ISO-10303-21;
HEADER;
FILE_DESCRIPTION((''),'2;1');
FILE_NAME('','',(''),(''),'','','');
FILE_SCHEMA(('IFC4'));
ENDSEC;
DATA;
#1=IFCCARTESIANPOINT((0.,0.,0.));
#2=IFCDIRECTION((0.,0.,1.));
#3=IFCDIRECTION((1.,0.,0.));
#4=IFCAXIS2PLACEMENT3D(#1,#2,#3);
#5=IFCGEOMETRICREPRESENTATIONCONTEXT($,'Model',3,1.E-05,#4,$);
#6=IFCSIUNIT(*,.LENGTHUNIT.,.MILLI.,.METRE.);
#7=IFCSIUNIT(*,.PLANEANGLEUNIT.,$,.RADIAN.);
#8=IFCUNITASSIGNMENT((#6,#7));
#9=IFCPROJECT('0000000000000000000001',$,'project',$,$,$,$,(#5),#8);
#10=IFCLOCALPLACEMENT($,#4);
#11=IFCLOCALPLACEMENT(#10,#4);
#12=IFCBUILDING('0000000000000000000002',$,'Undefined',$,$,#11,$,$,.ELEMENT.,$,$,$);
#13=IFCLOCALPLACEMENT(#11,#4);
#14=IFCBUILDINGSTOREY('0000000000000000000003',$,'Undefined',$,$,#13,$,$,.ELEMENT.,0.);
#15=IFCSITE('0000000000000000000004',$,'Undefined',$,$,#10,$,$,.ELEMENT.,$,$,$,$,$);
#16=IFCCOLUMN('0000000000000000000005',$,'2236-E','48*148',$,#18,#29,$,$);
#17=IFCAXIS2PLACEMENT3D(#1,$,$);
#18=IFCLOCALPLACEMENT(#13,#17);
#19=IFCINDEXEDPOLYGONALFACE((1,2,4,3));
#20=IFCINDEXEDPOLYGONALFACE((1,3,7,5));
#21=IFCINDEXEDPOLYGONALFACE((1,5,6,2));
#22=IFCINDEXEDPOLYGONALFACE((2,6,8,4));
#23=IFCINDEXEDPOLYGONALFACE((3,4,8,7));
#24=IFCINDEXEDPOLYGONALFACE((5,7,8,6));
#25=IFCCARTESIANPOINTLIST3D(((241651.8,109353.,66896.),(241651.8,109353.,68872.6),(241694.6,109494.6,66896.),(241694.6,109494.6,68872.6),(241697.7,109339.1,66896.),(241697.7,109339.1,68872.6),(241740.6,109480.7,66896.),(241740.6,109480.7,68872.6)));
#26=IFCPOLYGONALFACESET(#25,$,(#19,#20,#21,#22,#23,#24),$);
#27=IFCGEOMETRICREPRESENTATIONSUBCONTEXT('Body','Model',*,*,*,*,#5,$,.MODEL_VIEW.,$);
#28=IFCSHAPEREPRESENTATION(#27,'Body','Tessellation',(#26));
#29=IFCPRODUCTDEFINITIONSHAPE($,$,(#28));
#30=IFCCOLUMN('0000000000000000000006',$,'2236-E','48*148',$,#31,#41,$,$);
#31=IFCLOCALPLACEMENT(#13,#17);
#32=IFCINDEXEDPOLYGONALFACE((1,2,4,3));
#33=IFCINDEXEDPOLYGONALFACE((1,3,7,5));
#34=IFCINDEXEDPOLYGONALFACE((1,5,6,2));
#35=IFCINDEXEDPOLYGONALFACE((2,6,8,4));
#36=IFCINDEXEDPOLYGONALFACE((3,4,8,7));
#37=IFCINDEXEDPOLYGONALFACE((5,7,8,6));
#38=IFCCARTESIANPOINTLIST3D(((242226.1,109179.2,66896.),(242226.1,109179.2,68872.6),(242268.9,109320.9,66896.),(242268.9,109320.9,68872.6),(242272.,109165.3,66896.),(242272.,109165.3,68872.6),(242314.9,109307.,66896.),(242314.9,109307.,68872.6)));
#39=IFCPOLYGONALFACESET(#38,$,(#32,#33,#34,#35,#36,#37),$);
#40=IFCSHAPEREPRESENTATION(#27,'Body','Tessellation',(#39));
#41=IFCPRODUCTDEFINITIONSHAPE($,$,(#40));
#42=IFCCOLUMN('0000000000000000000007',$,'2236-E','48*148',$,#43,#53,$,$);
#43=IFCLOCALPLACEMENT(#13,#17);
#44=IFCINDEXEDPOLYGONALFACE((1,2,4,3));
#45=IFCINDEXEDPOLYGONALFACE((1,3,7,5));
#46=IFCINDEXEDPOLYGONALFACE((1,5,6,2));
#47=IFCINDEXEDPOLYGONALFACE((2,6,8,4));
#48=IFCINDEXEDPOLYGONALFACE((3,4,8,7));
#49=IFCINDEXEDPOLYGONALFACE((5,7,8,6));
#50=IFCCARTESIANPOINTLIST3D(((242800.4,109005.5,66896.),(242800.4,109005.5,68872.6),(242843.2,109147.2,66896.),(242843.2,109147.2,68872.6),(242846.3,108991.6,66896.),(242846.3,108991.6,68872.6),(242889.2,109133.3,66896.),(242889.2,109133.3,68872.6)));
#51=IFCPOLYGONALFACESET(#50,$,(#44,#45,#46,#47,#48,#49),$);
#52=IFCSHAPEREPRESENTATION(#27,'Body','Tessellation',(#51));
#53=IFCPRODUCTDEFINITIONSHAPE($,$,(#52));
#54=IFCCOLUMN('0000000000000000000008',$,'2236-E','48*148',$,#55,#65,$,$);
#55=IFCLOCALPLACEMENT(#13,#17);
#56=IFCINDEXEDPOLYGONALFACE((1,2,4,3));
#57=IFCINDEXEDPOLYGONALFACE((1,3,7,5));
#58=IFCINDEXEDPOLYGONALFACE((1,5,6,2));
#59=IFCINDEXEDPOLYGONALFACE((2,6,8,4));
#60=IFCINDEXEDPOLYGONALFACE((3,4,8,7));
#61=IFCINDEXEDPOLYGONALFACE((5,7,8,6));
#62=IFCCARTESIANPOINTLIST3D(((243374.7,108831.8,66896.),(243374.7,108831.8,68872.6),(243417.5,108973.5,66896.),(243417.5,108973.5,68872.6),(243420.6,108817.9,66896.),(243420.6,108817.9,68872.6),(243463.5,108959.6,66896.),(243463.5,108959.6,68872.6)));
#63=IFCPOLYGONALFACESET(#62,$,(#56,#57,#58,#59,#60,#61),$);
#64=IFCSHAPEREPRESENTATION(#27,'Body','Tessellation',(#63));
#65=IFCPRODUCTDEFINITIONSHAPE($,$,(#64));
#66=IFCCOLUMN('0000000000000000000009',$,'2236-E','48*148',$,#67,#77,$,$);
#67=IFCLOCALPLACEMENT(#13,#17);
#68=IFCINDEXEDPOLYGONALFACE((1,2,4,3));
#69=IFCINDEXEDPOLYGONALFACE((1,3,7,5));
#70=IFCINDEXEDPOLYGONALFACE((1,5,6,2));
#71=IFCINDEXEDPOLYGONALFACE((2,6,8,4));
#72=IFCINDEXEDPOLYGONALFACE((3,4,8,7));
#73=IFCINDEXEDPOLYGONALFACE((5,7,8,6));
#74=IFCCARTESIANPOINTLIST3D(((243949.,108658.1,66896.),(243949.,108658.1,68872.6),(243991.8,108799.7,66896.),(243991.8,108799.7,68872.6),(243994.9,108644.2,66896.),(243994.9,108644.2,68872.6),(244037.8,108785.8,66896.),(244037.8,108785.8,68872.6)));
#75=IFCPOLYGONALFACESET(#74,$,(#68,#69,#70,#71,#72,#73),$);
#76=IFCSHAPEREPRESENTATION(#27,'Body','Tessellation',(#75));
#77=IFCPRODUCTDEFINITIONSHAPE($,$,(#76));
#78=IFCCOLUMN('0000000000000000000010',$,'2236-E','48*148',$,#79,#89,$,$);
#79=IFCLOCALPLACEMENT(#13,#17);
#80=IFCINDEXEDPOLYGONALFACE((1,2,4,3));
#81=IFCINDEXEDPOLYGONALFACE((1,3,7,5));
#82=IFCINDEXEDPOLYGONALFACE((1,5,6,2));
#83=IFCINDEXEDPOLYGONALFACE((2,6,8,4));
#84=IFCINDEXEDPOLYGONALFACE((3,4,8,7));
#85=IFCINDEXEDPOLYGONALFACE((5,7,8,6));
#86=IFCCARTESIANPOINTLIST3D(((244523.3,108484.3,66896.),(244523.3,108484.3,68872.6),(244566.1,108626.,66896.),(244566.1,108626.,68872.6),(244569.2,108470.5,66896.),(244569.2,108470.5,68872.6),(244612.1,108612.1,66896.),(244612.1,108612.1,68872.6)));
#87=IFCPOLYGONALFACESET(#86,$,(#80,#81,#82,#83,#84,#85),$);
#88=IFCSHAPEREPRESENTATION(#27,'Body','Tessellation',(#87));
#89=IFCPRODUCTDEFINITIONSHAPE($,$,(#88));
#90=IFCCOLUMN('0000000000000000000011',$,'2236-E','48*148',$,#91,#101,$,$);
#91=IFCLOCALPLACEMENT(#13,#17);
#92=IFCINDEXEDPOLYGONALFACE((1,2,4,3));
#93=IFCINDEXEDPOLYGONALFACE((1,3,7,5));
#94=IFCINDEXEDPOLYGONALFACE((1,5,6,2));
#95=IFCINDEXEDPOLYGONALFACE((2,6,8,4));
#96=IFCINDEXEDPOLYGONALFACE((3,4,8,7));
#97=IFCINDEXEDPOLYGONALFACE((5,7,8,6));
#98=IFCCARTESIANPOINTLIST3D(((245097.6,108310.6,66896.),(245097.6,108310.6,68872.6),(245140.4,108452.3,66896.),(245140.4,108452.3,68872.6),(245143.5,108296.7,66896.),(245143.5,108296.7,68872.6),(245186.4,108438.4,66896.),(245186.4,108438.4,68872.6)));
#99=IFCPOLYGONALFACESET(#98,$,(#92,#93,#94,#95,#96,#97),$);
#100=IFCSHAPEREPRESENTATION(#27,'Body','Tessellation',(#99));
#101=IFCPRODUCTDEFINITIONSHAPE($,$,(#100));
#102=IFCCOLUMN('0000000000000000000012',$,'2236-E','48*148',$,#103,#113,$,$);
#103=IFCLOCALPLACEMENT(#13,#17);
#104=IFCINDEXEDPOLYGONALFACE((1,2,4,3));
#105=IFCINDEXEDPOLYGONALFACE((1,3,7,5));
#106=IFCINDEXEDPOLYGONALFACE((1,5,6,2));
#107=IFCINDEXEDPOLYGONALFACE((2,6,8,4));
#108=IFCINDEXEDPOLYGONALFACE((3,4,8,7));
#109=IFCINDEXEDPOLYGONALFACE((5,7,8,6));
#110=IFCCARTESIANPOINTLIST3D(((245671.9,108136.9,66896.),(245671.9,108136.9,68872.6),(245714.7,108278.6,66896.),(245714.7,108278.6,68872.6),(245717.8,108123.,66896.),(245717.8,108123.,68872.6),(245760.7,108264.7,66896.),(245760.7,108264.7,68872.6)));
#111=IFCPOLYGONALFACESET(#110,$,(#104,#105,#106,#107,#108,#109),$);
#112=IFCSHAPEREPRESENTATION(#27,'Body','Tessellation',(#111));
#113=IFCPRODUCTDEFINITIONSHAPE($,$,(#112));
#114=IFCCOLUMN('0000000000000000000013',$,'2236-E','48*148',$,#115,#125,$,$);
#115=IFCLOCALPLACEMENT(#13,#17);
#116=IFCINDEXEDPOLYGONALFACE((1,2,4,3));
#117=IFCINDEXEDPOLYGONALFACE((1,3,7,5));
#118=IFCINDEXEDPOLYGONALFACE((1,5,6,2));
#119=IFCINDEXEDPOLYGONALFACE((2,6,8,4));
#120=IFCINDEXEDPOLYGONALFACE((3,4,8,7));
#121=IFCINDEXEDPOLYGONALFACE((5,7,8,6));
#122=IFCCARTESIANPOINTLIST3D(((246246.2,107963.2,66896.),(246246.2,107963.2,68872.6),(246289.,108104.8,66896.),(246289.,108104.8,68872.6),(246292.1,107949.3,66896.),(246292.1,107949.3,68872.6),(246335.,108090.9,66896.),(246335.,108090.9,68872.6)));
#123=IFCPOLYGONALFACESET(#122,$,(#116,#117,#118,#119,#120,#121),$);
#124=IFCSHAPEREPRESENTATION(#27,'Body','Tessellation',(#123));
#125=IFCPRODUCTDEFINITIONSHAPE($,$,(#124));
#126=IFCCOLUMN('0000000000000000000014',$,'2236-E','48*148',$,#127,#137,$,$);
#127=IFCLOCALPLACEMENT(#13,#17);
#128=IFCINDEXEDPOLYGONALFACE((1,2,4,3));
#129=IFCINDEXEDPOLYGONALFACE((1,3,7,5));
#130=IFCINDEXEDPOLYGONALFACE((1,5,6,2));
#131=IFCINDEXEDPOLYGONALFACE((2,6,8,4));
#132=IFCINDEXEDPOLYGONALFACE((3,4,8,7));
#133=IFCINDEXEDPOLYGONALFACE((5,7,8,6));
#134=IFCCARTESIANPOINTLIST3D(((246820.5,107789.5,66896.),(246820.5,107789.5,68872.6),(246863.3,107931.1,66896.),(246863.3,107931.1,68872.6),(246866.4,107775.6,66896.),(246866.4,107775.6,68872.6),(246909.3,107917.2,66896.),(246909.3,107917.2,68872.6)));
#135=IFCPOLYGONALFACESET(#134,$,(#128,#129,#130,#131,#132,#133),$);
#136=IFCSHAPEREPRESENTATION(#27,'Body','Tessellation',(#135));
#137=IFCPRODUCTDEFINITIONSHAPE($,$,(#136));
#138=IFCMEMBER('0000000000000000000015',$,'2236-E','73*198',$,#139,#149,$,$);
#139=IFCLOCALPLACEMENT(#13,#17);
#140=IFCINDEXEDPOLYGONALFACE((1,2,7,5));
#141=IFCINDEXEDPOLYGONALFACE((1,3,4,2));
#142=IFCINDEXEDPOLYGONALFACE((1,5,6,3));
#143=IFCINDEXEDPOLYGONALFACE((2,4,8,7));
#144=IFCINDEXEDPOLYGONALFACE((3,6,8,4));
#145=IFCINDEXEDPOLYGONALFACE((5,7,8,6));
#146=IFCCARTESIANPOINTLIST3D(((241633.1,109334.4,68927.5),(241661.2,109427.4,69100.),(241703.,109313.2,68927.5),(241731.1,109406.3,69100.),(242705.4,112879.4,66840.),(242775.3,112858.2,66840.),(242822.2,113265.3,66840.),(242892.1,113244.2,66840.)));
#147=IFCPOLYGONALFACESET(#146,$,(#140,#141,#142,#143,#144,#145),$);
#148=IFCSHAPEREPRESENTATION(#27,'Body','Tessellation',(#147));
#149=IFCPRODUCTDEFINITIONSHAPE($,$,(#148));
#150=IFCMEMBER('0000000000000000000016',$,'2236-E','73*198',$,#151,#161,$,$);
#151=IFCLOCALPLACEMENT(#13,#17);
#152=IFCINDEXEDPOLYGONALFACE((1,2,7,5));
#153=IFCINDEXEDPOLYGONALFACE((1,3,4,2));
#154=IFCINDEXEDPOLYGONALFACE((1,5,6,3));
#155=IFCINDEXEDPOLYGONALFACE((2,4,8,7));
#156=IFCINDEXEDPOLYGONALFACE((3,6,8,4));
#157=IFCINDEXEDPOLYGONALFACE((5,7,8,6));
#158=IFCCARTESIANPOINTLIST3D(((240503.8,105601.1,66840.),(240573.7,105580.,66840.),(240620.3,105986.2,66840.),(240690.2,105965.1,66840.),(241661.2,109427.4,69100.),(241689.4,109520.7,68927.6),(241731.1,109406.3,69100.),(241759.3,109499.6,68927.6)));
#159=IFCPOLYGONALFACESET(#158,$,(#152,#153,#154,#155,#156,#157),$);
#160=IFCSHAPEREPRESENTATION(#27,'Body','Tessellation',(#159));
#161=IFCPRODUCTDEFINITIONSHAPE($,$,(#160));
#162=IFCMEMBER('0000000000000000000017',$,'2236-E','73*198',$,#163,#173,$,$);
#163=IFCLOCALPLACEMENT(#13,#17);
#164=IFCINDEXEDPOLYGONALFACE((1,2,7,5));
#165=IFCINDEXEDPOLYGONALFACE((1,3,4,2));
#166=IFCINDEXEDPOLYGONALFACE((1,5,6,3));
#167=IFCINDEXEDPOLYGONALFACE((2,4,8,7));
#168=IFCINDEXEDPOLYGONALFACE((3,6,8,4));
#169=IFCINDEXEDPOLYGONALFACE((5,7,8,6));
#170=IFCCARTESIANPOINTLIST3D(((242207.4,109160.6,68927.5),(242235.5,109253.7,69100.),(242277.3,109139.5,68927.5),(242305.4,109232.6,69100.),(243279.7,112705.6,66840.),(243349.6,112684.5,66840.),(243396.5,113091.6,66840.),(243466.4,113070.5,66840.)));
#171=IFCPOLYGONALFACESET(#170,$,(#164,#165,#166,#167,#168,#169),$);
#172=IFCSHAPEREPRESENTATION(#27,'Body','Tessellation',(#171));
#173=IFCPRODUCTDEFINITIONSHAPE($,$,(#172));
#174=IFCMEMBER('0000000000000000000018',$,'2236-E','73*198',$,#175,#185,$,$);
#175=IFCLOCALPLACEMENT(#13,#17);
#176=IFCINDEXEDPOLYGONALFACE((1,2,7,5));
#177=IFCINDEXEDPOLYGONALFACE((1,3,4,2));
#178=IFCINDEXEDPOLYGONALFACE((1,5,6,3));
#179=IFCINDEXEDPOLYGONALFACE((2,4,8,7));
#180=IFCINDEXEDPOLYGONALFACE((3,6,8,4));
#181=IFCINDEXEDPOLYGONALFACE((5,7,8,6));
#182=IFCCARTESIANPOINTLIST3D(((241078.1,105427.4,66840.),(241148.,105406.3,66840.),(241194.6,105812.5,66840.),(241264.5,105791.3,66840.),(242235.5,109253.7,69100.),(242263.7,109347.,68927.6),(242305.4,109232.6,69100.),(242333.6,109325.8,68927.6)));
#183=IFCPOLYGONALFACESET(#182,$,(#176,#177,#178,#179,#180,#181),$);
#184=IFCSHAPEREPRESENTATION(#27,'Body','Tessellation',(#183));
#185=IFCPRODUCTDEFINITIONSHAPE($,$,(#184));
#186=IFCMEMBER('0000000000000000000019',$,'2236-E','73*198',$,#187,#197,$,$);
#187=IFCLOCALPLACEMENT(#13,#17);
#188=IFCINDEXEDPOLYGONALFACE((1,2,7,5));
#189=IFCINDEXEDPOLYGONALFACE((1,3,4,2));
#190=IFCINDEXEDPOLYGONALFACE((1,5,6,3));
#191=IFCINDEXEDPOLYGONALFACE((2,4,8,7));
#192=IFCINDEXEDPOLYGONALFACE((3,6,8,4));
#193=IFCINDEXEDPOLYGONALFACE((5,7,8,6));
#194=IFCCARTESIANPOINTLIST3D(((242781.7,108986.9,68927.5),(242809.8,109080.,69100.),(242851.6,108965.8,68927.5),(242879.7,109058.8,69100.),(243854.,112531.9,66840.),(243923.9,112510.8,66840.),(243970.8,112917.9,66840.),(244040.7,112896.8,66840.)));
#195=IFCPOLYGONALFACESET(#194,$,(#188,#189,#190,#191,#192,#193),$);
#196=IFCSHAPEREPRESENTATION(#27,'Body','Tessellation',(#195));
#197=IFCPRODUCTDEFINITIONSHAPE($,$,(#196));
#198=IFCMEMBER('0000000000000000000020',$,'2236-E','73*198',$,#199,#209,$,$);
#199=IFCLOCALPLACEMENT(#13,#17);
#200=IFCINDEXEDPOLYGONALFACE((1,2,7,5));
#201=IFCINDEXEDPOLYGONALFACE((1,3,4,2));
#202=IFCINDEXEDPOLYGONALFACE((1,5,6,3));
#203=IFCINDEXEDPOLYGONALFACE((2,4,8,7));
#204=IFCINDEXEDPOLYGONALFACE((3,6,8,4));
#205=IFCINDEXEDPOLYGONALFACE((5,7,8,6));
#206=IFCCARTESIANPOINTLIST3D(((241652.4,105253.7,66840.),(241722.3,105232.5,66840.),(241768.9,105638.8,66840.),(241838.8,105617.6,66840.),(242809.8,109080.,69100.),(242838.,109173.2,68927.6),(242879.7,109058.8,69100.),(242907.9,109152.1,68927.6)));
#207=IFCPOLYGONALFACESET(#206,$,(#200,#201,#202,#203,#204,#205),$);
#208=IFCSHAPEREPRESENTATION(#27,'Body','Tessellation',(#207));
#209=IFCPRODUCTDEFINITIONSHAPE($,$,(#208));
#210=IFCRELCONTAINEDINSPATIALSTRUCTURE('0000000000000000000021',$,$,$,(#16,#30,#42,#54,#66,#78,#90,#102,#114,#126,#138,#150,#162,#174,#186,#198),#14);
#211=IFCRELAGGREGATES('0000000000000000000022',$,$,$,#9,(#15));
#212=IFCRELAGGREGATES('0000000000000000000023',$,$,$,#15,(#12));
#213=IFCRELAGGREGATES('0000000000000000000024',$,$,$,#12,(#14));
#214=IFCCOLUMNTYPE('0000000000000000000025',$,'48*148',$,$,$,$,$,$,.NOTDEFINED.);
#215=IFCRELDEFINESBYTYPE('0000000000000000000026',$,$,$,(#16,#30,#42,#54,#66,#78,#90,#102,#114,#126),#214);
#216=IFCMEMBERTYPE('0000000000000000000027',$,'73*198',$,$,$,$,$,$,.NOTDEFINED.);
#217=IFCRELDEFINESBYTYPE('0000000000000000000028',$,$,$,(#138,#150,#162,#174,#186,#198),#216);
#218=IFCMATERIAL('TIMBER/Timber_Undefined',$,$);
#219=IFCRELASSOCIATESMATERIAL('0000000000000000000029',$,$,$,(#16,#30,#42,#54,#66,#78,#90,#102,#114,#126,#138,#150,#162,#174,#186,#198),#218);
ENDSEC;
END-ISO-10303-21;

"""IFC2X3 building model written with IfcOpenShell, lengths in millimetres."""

from ifc_helpers import new_model, si_unit, frame, origin_with_axes, origin_2d_with_axis, place, context, subcontext, project, spatial, rectangle, extrude, clip, halfspace, material, type_object, element, save


model = new_model("IFC2X3")

# Units and contexts
model_context = context("Model", 3, precision=1e-05, world=origin_with_axes())
body_context = subcontext(model_context, "Body", "Model", "MODEL_VIEW")
ifc_project = project(units=[si_unit("LENGTHUNIT", "METRE", prefix="MILLI"), si_unit("PLANEANGLEUNIT", "RADIAN")], contexts=[model_context])

# Site, building, storey
site_placement = place(None, origin_with_axes())
site = spatial("IfcSite", under=ifc_project, at=site_placement, Name="Undefined", CompositionType="ELEMENT")
building_placement = place(site_placement, origin_with_axes())
building = spatial("IfcBuilding", under=site, at=building_placement, Name="Undefined", CompositionType="ELEMENT")
storey_placement = place(building_placement, origin_with_axes())
storey = spatial("IfcBuildingStorey", under=building, at=storey_placement, Name="Undefined", CompositionType="ELEMENT", Elevation=0.0)

# Columns
ifc_material_1 = material(Name="TIMBER/Timber_Undefined")
column_type = type_object("IfcColumnType", Name="48*148", PredefinedType="NOTDEFINED")
for number, where, z_axis, x_axis, name in (
    (1, (241696.2, 109416.8, 68872.6), (0.0, 0.0, -1.0), (0.957167, -0.289538, 0.0), "2236-E"),
    (2, (242270.5, 109243.1, 68872.6), (0.0, 0.0, -1.0), (0.957167, -0.289538, 0.0), "2236-E"),
    (3, (242844.8, 109069.4, 68872.6), (0.0, 0.0, -1.0), (0.957167, -0.289538, 0.0), "2236-E"),
    (4, (243419.1, 108895.7, 68872.6), (0.0, 0.0, -1.0), (0.957167, -0.289538, 0.0), "2236-E"),
    (5, (243993.4, 108722.0, 68872.6), (0.0, 0.0, -1.0), (0.957167, -0.289538, 0.0), "2236-E"),
    (6, (244567.7, 108548.2, 68872.6), (0.0, 0.0, -1.0), (0.957167, -0.289538, 0.0), "2236-E"),
    (7, (245142.0, 108374.5, 68872.6), (0.0, 0.0, -1.0), (0.957167, -0.289538, 0.0), "2236-E"),
    (8, (245716.3, 108200.8, 68872.6), (0.0, 0.0, -1.0), (0.957167, -0.289538, 0.0), "2236-E"),
    (9, (246290.6, 108027.1, 68872.6), (0.0, 0.0, -1.0), (0.957167, -0.289538, 0.0), "2236-E"),
    (10, (246864.9, 107853.3, 68872.6), (0.0, 0.0, -1.0), (0.957167, -0.289538, 0.0), "2236-E"),
):
    element("IfcColumn", number, at=place(storey_placement, frame(where, z_axis=z_axis, x_axis=x_axis)), inside=storey, type_object=column_type, material=ifc_material_1, Name=name, Description="48*148", context=body_context, shape_type="SweptSolid", body=[
        extrude(rectangle(XDim=148.0, YDim=48.0, at=origin_2d_with_axis()), frame((0.0, 0.0, 1976.6), z_axis=(0.0, 0.0, -1.0), x_axis=(0.0, 1.0, 0.0)), (0.0, 0.0, 1.0), 1976.6),
    ])

# Members
member_type = type_object("IfcMemberType", Name="73*198", PredefinedType="NOTDEFINED")
member_1_placement = place(storey_placement, frame((241682.1, 109370.3, 69013.8), z_axis=(-0.957167, 0.289538, 0.0), x_axis=(0.252232, 0.833838, -0.491013)))
element("IfcMember", 11, at=member_1_placement, inside=storey, type_object=member_type, material=ifc_material_1, Name="2236-E", Description="73*198", context=body_context, shape_type="Clipping", body=[
    clip(extrude(rectangle(XDim=198.0, YDim=73.0, at=origin_2d_with_axis()), frame((9470.2, 0.0, 0.0), z_axis=(-1.0, 0.0, 0.0), x_axis=(0.0, -1.0, 0.0)), (0.0, 0.0, 1.0), 9470.2), halfspace(frame((4746.2, -179.9, -36.5), z_axis=(0.491013, 0.871152, 0.0), x_axis=(0.0, 0.0, 1.0)), False)),
])
member_2_placement = place(storey_placement, frame((241710.3, 109463.5, 69013.8), z_axis=(-0.957167, 0.289538, 0.0), x_axis=(-0.252047, -0.833226, -0.492144)))
element("IfcMember", 12, at=member_2_placement, inside=storey, type_object=member_type, material=ifc_material_1, Name="2236-E", Description="73*198", context=body_context, shape_type="Clipping", body=[
    clip(extrude(rectangle(XDim=198.0, YDim=73.0, at=origin_2d_with_axis()), frame((9448.4, 0.0, 0.0), z_axis=(-1.0, 0.0, 0.0), x_axis=(0.0, -1.0, 0.0)), (0.0, 0.0, 1.0), 9448.5), halfspace(frame((4746.1, 186.1, 36.5), z_axis=(0.492144, -0.870514, 0.0), x_axis=(0.0, 0.0, -1.0)), False)),
])
member_3_placement = place(storey_placement, frame((242256.4, 109196.6, 69013.8), z_axis=(-0.957167, 0.289538, 0.0), x_axis=(0.252232, 0.833838, -0.491013)))
element("IfcMember", 13, at=member_3_placement, inside=storey, type_object=member_type, material=ifc_material_1, Name="2236-E", Description="73*198", context=body_context, shape_type="Clipping", body=[
    clip(extrude(rectangle(XDim=198.0, YDim=73.0, at=origin_2d_with_axis()), frame((9470.2, 0.0, 0.0), z_axis=(-1.0, 0.0, 0.0), x_axis=(0.0, -1.0, 0.0)), (0.0, 0.0, 1.0), 9470.2), halfspace(frame((4746.2, -179.9, -36.5), z_axis=(0.491013, 0.871152, 0.0), x_axis=(0.0, 0.0, 1.0)), False)),
])
member_4_placement = place(storey_placement, frame((242284.6, 109289.8, 69013.8), z_axis=(-0.957167, 0.289538, 0.0), x_axis=(-0.252047, -0.833226, -0.492144)))
element("IfcMember", 14, at=member_4_placement, inside=storey, type_object=member_type, material=ifc_material_1, Name="2236-E", Description="73*198", context=body_context, shape_type="Clipping", body=[
    clip(extrude(rectangle(XDim=198.0, YDim=73.0, at=origin_2d_with_axis()), frame((9448.4, 0.0, 0.0), z_axis=(-1.0, 0.0, 0.0), x_axis=(0.0, -1.0, 0.0)), (0.0, 0.0, 1.0), 9448.5), halfspace(frame((4746.1, 186.1, 36.5), z_axis=(0.492144, -0.870514, 0.0), x_axis=(0.0, 0.0, -1.0)), False)),
])
member_5_placement = place(storey_placement, frame((242830.7, 109022.9, 69013.8), z_axis=(-0.957167, 0.289538, 0.0), x_axis=(0.252232, 0.833838, -0.491013)))
element("IfcMember", 15, at=member_5_placement, inside=storey, type_object=member_type, material=ifc_material_1, Name="2236-E", Description="73*198", context=body_context, shape_type="Clipping", body=[
    clip(extrude(rectangle(XDim=198.0, YDim=73.0, at=origin_2d_with_axis()), frame((9470.2, 0.0, 0.0), z_axis=(-1.0, 0.0, 0.0), x_axis=(0.0, -1.0, 0.0)), (0.0, 0.0, 1.0), 9470.2), halfspace(frame((4746.2, -179.9, -36.5), z_axis=(0.491013, 0.871152, 0.0), x_axis=(0.0, 0.0, 1.0)), False)),
])
member_6_placement = place(storey_placement, frame((242858.9, 109116.0, 69013.8), z_axis=(-0.957167, 0.289538, 0.0), x_axis=(-0.252047, -0.833226, -0.492144)))
element("IfcMember", 16, at=member_6_placement, inside=storey, type_object=member_type, material=ifc_material_1, Name="2236-E", Description="73*198", context=body_context, shape_type="Clipping", body=[
    clip(extrude(rectangle(XDim=198.0, YDim=73.0, at=origin_2d_with_axis()), frame((9448.4, 0.0, 0.0), z_axis=(-1.0, 0.0, 0.0), x_axis=(0.0, -1.0, 0.0)), (0.0, 0.0, 1.0), 9448.5), halfspace(frame((4746.1, 186.1, 36.5), z_axis=(0.492144, -0.870514, 0.0), x_axis=(0.0, 0.0, -1.0)), False)),
])

save(model, "model.ifc")
